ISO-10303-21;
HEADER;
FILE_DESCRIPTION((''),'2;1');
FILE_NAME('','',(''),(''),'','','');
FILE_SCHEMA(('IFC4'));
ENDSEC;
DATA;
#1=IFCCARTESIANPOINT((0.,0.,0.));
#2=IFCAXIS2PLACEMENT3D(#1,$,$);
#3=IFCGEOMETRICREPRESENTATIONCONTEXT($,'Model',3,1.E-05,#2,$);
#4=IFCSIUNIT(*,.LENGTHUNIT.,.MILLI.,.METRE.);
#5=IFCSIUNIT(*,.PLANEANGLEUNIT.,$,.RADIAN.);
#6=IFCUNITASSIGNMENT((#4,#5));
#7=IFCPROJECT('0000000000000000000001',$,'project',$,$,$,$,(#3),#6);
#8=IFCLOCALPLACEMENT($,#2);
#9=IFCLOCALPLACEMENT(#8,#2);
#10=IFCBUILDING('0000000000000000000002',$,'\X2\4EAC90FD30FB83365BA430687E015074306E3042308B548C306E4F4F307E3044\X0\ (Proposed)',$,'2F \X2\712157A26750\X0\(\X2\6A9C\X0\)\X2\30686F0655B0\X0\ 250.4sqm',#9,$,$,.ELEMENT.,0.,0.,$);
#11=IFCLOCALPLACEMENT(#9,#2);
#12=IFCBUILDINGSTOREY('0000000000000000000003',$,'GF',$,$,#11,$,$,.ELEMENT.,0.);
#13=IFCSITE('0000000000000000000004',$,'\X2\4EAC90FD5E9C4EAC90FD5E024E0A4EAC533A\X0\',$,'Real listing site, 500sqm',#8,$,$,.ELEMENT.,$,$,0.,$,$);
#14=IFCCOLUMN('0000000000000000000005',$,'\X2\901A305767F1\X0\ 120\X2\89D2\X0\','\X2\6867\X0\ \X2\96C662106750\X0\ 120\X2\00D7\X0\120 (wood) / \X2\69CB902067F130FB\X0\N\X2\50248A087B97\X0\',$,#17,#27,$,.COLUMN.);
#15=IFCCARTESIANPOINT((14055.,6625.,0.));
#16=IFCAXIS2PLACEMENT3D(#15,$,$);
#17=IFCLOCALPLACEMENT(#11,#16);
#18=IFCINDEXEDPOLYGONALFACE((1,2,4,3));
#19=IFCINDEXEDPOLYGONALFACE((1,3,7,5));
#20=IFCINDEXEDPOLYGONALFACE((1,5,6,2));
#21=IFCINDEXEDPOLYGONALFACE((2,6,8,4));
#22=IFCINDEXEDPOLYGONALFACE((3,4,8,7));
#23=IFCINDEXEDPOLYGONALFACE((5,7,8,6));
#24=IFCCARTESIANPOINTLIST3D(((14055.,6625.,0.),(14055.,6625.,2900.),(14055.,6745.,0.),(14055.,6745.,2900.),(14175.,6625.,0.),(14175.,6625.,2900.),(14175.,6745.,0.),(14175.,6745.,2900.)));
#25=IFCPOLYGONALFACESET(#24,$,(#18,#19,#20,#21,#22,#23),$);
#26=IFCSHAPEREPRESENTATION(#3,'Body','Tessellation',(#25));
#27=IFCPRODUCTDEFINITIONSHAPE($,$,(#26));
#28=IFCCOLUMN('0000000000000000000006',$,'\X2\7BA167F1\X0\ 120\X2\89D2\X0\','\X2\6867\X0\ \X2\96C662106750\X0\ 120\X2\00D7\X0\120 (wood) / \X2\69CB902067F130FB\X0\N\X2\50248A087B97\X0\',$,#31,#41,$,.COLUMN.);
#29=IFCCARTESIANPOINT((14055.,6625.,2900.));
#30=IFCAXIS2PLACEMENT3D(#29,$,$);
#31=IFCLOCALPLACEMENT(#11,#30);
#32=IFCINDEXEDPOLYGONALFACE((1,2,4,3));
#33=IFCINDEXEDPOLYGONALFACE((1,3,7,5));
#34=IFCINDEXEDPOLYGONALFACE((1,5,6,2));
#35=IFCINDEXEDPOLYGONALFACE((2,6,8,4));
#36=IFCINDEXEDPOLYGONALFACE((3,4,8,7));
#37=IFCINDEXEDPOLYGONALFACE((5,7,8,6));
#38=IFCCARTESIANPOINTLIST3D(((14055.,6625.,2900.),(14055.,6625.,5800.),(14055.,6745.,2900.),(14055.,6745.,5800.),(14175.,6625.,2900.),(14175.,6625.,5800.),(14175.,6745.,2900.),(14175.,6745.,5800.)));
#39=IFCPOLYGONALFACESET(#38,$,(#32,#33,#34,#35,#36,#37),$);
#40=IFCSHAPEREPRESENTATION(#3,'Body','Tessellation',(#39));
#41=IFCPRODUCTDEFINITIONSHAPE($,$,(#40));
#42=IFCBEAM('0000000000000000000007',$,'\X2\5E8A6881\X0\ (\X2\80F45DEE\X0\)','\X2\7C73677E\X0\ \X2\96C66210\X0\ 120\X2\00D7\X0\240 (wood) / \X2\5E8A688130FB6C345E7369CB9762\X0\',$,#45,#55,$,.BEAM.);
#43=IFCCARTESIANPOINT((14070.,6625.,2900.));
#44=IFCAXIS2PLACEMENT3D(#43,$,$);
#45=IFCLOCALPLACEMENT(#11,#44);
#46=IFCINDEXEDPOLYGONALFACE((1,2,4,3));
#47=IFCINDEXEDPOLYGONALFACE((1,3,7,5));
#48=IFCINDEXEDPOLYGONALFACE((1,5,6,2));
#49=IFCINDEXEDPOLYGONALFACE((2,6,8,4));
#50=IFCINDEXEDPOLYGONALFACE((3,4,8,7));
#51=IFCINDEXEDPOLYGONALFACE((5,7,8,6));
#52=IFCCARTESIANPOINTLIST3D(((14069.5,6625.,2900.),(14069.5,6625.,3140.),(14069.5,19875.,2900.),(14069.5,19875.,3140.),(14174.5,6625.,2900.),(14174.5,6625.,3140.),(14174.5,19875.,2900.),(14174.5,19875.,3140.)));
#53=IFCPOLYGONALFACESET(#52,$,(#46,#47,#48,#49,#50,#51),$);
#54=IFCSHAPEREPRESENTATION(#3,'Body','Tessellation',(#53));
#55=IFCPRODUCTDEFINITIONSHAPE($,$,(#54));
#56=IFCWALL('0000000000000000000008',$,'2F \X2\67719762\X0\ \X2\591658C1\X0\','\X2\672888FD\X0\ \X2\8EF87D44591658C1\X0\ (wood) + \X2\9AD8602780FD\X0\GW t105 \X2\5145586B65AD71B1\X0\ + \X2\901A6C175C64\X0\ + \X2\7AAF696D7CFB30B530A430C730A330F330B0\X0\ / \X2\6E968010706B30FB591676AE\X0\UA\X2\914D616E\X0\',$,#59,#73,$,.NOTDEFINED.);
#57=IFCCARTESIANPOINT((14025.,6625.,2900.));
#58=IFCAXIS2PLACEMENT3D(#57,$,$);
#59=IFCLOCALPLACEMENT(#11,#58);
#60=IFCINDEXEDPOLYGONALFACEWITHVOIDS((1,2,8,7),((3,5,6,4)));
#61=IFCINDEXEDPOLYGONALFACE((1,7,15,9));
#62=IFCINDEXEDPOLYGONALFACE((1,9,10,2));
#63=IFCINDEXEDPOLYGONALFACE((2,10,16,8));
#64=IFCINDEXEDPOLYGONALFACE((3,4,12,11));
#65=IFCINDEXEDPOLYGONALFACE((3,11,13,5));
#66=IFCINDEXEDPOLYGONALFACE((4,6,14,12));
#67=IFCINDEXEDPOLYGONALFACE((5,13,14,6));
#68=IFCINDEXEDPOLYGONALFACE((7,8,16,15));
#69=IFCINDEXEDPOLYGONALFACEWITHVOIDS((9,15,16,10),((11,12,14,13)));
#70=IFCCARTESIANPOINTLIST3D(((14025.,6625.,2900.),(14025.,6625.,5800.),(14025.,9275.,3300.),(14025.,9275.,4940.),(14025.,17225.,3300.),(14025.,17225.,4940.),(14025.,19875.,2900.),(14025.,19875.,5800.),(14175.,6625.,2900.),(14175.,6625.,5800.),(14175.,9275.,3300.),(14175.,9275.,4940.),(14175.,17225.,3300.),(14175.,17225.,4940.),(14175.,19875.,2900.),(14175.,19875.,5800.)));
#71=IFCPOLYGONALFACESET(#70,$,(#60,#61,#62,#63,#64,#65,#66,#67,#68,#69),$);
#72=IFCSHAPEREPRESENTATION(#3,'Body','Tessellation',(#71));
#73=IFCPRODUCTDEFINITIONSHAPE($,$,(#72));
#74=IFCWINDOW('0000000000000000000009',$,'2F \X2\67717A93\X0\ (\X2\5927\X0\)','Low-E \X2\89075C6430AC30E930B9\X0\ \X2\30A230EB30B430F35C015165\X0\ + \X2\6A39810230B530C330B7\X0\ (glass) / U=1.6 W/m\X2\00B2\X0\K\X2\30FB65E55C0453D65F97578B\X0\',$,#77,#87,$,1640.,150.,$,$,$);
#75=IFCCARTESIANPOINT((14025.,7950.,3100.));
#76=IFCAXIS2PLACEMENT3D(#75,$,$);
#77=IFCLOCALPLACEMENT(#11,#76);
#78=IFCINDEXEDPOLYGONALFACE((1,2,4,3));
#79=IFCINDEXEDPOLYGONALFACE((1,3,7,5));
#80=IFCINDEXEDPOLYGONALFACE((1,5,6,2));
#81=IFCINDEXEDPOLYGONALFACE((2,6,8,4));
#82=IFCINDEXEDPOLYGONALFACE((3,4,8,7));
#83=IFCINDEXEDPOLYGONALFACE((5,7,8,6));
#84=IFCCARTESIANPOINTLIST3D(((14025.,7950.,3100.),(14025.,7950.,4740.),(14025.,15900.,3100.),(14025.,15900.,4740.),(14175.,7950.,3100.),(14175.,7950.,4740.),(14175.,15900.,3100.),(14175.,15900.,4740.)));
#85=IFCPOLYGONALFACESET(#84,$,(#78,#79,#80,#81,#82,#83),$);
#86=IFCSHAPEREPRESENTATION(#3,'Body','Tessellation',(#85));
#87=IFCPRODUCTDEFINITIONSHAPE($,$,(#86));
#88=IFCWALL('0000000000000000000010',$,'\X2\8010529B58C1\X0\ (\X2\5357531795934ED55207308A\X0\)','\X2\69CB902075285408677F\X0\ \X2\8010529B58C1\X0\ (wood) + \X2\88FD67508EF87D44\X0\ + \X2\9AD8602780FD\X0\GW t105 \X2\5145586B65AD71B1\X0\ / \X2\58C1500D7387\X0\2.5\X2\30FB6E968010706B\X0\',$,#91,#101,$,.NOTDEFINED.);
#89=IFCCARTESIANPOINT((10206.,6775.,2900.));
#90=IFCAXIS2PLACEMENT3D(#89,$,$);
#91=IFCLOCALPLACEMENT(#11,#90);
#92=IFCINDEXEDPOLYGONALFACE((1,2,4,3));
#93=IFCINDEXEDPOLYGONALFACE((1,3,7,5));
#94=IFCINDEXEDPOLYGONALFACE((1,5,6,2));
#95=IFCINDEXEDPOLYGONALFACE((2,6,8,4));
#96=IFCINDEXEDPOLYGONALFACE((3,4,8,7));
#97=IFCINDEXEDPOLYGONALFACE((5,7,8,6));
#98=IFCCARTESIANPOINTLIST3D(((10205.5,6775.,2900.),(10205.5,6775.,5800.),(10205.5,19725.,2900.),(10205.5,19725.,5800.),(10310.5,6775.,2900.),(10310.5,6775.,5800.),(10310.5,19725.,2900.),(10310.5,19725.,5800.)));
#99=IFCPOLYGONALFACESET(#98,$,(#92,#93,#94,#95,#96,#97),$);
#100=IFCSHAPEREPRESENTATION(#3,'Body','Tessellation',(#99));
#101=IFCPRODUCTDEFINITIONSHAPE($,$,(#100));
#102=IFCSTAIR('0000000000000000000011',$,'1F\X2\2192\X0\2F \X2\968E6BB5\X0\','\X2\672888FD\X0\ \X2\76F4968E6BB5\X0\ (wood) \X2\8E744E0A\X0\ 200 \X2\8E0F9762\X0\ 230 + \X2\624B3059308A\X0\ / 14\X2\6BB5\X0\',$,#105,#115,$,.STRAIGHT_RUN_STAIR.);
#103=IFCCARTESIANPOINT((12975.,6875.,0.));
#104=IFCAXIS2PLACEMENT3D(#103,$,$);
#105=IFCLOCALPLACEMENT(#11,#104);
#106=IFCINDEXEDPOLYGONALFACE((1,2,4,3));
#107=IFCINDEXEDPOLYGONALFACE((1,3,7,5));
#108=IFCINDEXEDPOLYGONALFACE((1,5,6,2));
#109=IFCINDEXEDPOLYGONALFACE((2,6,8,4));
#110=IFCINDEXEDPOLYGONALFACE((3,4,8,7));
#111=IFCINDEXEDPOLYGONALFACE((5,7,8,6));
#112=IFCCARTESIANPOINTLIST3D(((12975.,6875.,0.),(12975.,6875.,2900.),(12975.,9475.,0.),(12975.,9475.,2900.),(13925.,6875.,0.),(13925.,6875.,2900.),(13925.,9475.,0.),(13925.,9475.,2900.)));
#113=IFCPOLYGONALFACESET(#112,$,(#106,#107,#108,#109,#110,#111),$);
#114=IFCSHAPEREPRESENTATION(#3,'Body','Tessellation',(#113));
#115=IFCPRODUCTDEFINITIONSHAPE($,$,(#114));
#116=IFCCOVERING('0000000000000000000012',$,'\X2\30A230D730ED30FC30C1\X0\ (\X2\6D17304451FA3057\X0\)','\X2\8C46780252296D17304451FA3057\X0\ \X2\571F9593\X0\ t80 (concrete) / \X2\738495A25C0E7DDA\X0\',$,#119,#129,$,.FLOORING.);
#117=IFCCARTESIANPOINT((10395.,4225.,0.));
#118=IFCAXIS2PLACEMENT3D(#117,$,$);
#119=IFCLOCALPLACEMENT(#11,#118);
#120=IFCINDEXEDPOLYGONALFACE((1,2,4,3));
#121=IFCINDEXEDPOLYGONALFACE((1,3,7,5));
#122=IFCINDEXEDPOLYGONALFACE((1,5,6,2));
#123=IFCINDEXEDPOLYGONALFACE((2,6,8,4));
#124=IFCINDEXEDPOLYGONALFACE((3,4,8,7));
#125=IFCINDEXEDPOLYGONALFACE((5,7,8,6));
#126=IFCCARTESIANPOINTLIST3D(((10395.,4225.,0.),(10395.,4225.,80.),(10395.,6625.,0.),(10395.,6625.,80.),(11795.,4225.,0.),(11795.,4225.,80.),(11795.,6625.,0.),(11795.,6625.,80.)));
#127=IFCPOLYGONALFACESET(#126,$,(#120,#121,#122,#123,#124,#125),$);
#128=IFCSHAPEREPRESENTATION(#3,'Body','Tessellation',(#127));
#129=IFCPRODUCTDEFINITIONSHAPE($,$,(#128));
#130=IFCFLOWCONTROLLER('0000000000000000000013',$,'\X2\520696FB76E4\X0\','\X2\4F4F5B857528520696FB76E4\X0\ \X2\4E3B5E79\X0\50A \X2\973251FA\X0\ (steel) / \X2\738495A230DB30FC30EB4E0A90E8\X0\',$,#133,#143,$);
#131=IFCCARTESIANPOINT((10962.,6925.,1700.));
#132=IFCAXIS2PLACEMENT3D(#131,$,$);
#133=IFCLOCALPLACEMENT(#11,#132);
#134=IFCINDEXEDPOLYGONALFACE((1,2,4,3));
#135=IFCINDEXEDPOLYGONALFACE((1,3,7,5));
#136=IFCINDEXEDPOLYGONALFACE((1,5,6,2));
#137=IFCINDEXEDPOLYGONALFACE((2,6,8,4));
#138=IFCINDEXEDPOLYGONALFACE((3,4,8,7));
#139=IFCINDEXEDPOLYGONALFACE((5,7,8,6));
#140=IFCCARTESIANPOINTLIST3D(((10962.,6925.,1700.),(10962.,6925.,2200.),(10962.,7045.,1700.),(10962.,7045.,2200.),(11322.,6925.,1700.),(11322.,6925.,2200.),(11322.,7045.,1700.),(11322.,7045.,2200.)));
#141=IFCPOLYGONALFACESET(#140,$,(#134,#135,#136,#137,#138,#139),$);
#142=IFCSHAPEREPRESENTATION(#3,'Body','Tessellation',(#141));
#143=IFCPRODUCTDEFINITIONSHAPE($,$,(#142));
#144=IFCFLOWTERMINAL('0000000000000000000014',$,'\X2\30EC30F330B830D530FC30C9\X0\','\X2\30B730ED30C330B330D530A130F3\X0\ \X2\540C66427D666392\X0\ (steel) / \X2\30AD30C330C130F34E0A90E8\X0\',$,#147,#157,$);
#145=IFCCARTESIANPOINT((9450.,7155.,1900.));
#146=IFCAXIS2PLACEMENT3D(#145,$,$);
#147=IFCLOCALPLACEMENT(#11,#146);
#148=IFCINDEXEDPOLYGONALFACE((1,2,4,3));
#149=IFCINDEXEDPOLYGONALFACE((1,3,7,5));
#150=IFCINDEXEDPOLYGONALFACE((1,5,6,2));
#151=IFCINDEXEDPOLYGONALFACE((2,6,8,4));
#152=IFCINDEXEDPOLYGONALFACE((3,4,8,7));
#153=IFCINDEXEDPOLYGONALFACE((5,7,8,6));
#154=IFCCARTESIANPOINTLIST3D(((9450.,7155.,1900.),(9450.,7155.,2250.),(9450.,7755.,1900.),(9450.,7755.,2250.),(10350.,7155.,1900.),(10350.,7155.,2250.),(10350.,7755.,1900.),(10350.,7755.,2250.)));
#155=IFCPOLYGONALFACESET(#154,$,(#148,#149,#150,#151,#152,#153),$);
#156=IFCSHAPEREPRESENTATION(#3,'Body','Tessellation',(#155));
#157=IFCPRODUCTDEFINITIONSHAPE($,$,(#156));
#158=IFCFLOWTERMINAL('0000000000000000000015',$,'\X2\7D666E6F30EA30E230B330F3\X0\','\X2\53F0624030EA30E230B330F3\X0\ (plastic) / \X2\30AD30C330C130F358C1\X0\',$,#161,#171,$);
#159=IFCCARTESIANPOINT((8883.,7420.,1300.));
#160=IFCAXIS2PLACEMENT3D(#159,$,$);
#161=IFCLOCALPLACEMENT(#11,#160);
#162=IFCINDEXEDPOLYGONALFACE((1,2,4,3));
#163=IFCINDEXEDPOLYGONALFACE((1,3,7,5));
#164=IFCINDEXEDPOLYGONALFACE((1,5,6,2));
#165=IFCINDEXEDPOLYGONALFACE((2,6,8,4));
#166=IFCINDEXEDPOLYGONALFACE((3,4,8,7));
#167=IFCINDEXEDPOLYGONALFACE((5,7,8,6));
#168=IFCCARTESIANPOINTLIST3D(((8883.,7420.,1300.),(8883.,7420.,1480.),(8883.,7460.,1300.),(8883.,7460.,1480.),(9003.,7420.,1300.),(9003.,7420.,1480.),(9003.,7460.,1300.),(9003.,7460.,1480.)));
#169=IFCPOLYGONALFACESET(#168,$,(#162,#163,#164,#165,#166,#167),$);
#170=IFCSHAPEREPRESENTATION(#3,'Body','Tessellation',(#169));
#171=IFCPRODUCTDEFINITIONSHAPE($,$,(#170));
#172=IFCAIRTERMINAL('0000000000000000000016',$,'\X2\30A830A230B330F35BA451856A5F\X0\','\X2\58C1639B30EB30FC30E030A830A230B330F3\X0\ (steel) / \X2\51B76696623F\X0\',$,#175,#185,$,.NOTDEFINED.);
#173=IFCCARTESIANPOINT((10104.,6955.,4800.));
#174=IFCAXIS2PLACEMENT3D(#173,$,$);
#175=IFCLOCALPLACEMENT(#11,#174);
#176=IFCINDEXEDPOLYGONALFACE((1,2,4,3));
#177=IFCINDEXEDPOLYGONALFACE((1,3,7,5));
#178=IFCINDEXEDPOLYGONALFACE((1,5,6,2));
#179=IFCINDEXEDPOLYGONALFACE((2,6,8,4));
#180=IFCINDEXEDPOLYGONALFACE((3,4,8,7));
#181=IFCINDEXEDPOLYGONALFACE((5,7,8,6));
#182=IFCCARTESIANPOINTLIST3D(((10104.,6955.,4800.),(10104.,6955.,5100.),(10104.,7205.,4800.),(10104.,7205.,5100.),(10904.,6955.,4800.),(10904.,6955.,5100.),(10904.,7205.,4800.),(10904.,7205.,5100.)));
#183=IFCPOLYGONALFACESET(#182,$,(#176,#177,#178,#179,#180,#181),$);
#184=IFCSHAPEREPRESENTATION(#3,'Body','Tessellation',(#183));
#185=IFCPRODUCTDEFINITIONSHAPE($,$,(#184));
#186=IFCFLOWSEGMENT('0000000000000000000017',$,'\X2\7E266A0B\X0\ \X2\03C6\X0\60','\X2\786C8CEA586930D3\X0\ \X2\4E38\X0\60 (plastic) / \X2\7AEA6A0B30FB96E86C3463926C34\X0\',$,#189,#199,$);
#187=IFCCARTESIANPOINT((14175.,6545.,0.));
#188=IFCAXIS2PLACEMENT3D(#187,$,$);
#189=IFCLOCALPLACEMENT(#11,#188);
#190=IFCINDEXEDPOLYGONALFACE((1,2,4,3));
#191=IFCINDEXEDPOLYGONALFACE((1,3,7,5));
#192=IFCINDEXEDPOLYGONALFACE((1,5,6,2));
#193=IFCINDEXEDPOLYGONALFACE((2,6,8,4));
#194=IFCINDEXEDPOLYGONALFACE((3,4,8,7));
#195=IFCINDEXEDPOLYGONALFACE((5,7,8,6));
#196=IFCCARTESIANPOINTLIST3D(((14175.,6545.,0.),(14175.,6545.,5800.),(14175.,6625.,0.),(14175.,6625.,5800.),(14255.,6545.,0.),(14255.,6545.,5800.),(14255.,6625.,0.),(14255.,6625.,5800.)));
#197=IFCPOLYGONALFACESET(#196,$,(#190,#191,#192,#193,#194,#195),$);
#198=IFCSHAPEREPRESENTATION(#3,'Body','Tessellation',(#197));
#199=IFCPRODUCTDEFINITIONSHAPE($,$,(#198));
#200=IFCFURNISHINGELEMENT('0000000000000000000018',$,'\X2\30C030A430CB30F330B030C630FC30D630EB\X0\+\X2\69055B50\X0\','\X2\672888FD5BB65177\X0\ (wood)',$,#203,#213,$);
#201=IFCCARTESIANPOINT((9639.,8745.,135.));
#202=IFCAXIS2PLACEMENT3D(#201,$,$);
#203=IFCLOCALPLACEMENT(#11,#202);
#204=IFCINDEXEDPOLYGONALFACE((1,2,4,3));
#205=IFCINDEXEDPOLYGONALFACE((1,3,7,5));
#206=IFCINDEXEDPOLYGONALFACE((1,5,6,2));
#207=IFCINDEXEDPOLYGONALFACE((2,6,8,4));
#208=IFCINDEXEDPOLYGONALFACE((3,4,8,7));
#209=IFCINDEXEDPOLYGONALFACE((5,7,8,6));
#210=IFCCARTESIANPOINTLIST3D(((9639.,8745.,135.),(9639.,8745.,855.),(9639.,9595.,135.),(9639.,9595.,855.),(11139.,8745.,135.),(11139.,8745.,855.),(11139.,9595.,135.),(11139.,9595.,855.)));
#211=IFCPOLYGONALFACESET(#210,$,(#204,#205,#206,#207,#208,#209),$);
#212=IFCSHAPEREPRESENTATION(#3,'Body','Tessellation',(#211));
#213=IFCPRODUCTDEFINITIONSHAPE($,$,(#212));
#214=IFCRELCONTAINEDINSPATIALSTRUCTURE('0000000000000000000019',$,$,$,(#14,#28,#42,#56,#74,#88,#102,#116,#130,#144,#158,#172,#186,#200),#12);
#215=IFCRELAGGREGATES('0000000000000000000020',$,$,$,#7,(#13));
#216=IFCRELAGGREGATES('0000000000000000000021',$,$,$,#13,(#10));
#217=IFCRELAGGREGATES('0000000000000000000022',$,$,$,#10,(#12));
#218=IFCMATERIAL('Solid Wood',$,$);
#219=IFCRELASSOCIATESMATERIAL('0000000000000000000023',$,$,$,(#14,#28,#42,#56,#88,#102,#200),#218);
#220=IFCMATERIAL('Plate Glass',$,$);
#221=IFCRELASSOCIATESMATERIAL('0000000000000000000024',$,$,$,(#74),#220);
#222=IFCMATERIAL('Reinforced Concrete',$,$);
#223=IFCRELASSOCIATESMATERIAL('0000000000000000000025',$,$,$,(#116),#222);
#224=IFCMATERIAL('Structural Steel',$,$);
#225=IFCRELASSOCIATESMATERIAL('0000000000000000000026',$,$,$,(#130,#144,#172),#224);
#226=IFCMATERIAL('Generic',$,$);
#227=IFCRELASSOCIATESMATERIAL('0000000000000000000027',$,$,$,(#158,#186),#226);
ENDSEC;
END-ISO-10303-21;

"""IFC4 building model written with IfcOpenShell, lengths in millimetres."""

from ifc_helpers import new_model, si_unit, frame, frame_2d, origin, place, context, project, spatial, rectangle, extrude, material, element, fill, save


model = new_model("IFC4")

# Units and contexts
model_context = context("Model", 3, precision=1e-05, world=origin())
ifc_project = project(units=[si_unit("LENGTHUNIT", "METRE", prefix="MILLI"), si_unit("PLANEANGLEUNIT", "RADIAN")], contexts=[model_context])

# Site, building, storey
site_placement = place(None, origin())
site = spatial("IfcSite", under=ifc_project, at=site_placement, Name="京都府京都市上京区", ObjectType="Real listing site, 500sqm", CompositionType="ELEMENT", RefElevation=0.0)
building_placement = place(site_placement, origin())
building = spatial("IfcBuilding", under=site, at=building_placement, Name="京都・茶室と縁側のある和の住まい (Proposed)", ObjectType="2F 無垢材(檜)と漆喰 250.4sqm", CompositionType="ELEMENT", ElevationOfRefHeight=0.0, ElevationOfTerrain=0.0)
storey_placement = place(building_placement, origin())
storey = spatial("IfcBuildingStorey", under=building, at=storey_placement, Name="GF", CompositionType="ELEMENT", Elevation=0.0)

# Columns
ifc_material_1 = material(Name="Solid Wood")
column_1_placement = place(storey_placement, frame((14055.0, 6625.0, 0.0)))
element("IfcColumn", 1, at=column_1_placement, inside=storey, material=ifc_material_1, Name="通し柱 120角", Description="桧 集成材 120×120 (wood) / 構造柱・N値計算", PredefinedType="COLUMN", context=model_context, shape_type="SweptSolid", body=[
    extrude(rectangle(XDim=120.0, YDim=120.0, at=frame_2d((60.0, 60.0))), frame((14055.0, 6625.0, 0.0)), (0.0, 0.0, 1.0), 2900.0),
])
column_2_placement = place(storey_placement, frame((14055.0, 6625.0, 2900.0)))
element("IfcColumn", 2, at=column_2_placement, inside=storey, material=ifc_material_1, Name="管柱 120角", Description="桧 集成材 120×120 (wood) / 構造柱・N値計算", PredefinedType="COLUMN", context=model_context, shape_type="SweptSolid", body=[
    extrude(rectangle(XDim=120.0, YDim=120.0, at=frame_2d((60.0, 60.0))), frame((14055.0, 6625.0, 2900.0)), (0.0, 0.0, 1.0), 2900.0),
])

# Beam
beam_1_placement = place(storey_placement, frame((14070.0, 6625.0, 2900.0)))
element("IfcBeam", 3, at=beam_1_placement, inside=storey, material=ifc_material_1, Name="床梁 (胴差)", Description="米松 集成 120×240 (wood) / 床梁・水平構面", PredefinedType="BEAM", context=model_context, shape_type="SweptSolid", body=[
    extrude(rectangle(XDim=105.0, YDim=13250.0, at=frame_2d((52.0, 6625.0))), frame((14070.0, 6625.0, 2900.0)), (0.0, 0.0, 1.0), 240.0),
])

# Shared definitions
ifc_material_2 = material(Name="Plate Glass")

# Wall, opening, window
wall_1_placement = place(storey_placement, frame((14025.0, 6625.0, 2900.0)))
wall_1 = element("IfcWall", 4, at=wall_1_placement, inside=storey, material=ifc_material_1, Name="2F 東面 外壁", Description="木製 軸組外壁 (wood) + 高性能GW t105 充填断熱 + 通気層 + 窯業系サイディング / 準耐火・外皮UA配慮", PredefinedType="NOTDEFINED", context=model_context, shape_type="SweptSolid", body=[
    extrude(rectangle(XDim=150.0, YDim=13250.0, at=frame_2d((75.0, 6625.0))), frame((14025.0, 6625.0, 2900.0)), (0.0, 0.0, 1.0), 2900.0),
])
opening_1_placement = place(storey_placement, frame((14025.0, 7950.0, 3100.0)))
opening_1 = element("IfcOpeningElement", 5, at=opening_1_placement, cuts=wall_1, PredefinedType="NOTDEFINED", context=model_context, shape_type="SweptSolid", body=[
    extrude(rectangle(XDim=150.0, YDim=7950.0, at=frame_2d((75.0, 3975.0))), frame((14025.0, 7950.0, 3100.0)), (0.0, 0.0, 1.0), 1640.0),
])
window_1_placement = place(storey_placement, frame((14025.0, 7950.0, 3100.0)))
window_1 = element("IfcWindow", 6, at=window_1_placement, inside=storey, material=ifc_material_2, Name="2F 東窓 (大)", Description="Low-E 複層ガラス アルゴン封入 + 樹脂サッシ (glass) / U=1.6 W/m²K・日射取得型", OverallHeight=1640.0, OverallWidth=150.0, context=model_context, shape_type="SweptSolid", body=[
    extrude(rectangle(XDim=150.0, YDim=7950.0, at=frame_2d((75.0, 3975.0))), frame((14025.0, 7950.0, 3100.0)), (0.0, 0.0, 1.0), 1640.0),
])
fill(opening_1, window_1)

# Wall
wall_2_placement = place(storey_placement, frame((10206.0, 6775.0, 2900.0)))
element("IfcWall", 7, at=wall_2_placement, inside=storey, material=ifc_material_1, Name="耐力壁 (南北間仕切り)", Description="構造用合板 耐力壁 (wood) + 製材軸組 + 高性能GW t105 充填断熱 / 壁倍率2.5・準耐火", PredefinedType="NOTDEFINED", context=model_context, shape_type="SweptSolid", body=[
    extrude(rectangle(XDim=105.0, YDim=12950.0, at=frame_2d((52.0, 6475.0))), frame((10206.0, 6775.0, 2900.0)), (0.0, 0.0, 1.0), 2900.0),
])

# Stair
stair_placement = place(storey_placement, frame((12975.0, 6875.0, 0.0)))
element("IfcStair", 8, at=stair_placement, inside=storey, material=ifc_material_1, Name="1F→2F 階段", Description="木製 直階段 (wood) 蹴上 200 踏面 230 + 手すり / 14段", PredefinedType="STRAIGHT_RUN_STAIR", context=model_context, shape_type="SweptSolid", body=[
    extrude(rectangle(XDim=950.0, YDim=2600.0, at=frame_2d((475.0, 1300.0))), frame((12975.0, 6875.0, 0.0)), (0.0, 0.0, 1.0), 2900.0),
])

# Covering
ifc_material_3 = material(Name="Reinforced Concrete")
covering_placement = place(storey_placement, frame((10395.0, 4225.0, 0.0)))
element("IfcCovering", 9, at=covering_placement, inside=storey, material=ifc_material_3, Name="アプローチ (洗い出し)", Description="豆砂利洗い出し 土間 t80 (concrete) / 玄関導線", PredefinedType="FLOORING", context=model_context, shape_type="SweptSolid", body=[
    extrude(rectangle(XDim=1400.0, YDim=2400.0, at=frame_2d((700.0, 1200.0))), frame((10395.0, 4225.0, 0.0)), (0.0, 0.0, 1.0), 80.0),
])

# Flow controller
ifc_material_4 = material(Name="Structural Steel")
flow_controller_placement = place(storey_placement, frame((10962.0, 6925.0, 1700.0)))
element("IfcFlowController", 10, at=flow_controller_placement, inside=storey, material=ifc_material_4, Name="分電盤", Description="住宅用分電盤 主幹50A 露出 (steel) / 玄関ホール上部", context=model_context, shape_type="SweptSolid", body=[
    extrude(rectangle(XDim=360.0, YDim=120.0, at=frame_2d((180.0, 60.0))), frame((10962.0, 6925.0, 1700.0)), (0.0, 0.0, 1.0), 500.0),
])

# Flow terminals
flow_terminal_1_placement = place(storey_placement, frame((9450.0, 7155.0, 1900.0)))
element("IfcFlowTerminal", 11, at=flow_terminal_1_placement, inside=storey, material=ifc_material_4, Name="レンジフード", Description="シロッコファン 同時給排 (steel) / キッチン上部", context=model_context, shape_type="SweptSolid", body=[
    extrude(rectangle(XDim=900.0, YDim=600.0, at=frame_2d((450.0, 300.0))), frame((9450.0, 7155.0, 1900.0)), (0.0, 0.0, 1.0), 350.0),
])
ifc_material_5 = material(Name="Generic")
flow_terminal_2_placement = place(storey_placement, frame((8883.0, 7420.0, 1300.0)))
element("IfcFlowTerminal", 12, at=flow_terminal_2_placement, inside=storey, material=ifc_material_5, Name="給湯リモコン", Description="台所リモコン (plastic) / キッチン壁", context=model_context, shape_type="SweptSolid", body=[
    extrude(rectangle(XDim=120.0, YDim=40.0, at=frame_2d((60.0, 20.0))), frame((8883.0, 7420.0, 1300.0)), (0.0, 0.0, 1.0), 180.0),
])

# Air terminal
air_terminal_placement = place(storey_placement, frame((10104.0, 6955.0, 4800.0)))
element("IfcAirTerminal", 13, at=air_terminal_placement, inside=storey, material=ifc_material_4, Name="エアコン室内機", Description="壁掛ルームエアコン (steel) / 冷暖房", PredefinedType="NOTDEFINED", context=model_context, shape_type="SweptSolid", body=[
    extrude(rectangle(XDim=800.0, YDim=250.0, at=frame_2d((400.0, 125.0))), frame((10104.0, 6955.0, 4800.0)), (0.0, 0.0, 1.0), 300.0),
])

# Flow segment
flow_segment_placement = place(storey_placement, frame((14175.0, 6545.0, 0.0)))
element("IfcFlowSegment", 14, at=flow_segment_placement, inside=storey, material=ifc_material_5, Name="縦樋 φ60", Description="硬質塩ビ 丸60 (plastic) / 竪樋・雨水排水", context=model_context, shape_type="SweptSolid", body=[
    extrude(rectangle(XDim=80.0, YDim=80.0, at=frame_2d((40.0, 40.0))), frame((14175.0, 6545.0, 0.0)), (0.0, 0.0, 1.0), 5800.0),
])

# Furnishing element
furnishing_1_placement = place(storey_placement, frame((9639.0, 8745.0, 135.0)))
element("IfcFurnishingElement", 15, at=furnishing_1_placement, inside=storey, material=ifc_material_1, Name="ダイニングテーブル+椅子", Description="木製家具 (wood)", context=model_context, shape_type="SweptSolid", body=[
    extrude(rectangle(XDim=1500.0, YDim=850.0, at=frame_2d((750.0, 425.0))), frame((9639.0, 8745.0, 135.0)), (0.0, 0.0, 1.0), 720.0),
])

save(model, "model.ifc")
